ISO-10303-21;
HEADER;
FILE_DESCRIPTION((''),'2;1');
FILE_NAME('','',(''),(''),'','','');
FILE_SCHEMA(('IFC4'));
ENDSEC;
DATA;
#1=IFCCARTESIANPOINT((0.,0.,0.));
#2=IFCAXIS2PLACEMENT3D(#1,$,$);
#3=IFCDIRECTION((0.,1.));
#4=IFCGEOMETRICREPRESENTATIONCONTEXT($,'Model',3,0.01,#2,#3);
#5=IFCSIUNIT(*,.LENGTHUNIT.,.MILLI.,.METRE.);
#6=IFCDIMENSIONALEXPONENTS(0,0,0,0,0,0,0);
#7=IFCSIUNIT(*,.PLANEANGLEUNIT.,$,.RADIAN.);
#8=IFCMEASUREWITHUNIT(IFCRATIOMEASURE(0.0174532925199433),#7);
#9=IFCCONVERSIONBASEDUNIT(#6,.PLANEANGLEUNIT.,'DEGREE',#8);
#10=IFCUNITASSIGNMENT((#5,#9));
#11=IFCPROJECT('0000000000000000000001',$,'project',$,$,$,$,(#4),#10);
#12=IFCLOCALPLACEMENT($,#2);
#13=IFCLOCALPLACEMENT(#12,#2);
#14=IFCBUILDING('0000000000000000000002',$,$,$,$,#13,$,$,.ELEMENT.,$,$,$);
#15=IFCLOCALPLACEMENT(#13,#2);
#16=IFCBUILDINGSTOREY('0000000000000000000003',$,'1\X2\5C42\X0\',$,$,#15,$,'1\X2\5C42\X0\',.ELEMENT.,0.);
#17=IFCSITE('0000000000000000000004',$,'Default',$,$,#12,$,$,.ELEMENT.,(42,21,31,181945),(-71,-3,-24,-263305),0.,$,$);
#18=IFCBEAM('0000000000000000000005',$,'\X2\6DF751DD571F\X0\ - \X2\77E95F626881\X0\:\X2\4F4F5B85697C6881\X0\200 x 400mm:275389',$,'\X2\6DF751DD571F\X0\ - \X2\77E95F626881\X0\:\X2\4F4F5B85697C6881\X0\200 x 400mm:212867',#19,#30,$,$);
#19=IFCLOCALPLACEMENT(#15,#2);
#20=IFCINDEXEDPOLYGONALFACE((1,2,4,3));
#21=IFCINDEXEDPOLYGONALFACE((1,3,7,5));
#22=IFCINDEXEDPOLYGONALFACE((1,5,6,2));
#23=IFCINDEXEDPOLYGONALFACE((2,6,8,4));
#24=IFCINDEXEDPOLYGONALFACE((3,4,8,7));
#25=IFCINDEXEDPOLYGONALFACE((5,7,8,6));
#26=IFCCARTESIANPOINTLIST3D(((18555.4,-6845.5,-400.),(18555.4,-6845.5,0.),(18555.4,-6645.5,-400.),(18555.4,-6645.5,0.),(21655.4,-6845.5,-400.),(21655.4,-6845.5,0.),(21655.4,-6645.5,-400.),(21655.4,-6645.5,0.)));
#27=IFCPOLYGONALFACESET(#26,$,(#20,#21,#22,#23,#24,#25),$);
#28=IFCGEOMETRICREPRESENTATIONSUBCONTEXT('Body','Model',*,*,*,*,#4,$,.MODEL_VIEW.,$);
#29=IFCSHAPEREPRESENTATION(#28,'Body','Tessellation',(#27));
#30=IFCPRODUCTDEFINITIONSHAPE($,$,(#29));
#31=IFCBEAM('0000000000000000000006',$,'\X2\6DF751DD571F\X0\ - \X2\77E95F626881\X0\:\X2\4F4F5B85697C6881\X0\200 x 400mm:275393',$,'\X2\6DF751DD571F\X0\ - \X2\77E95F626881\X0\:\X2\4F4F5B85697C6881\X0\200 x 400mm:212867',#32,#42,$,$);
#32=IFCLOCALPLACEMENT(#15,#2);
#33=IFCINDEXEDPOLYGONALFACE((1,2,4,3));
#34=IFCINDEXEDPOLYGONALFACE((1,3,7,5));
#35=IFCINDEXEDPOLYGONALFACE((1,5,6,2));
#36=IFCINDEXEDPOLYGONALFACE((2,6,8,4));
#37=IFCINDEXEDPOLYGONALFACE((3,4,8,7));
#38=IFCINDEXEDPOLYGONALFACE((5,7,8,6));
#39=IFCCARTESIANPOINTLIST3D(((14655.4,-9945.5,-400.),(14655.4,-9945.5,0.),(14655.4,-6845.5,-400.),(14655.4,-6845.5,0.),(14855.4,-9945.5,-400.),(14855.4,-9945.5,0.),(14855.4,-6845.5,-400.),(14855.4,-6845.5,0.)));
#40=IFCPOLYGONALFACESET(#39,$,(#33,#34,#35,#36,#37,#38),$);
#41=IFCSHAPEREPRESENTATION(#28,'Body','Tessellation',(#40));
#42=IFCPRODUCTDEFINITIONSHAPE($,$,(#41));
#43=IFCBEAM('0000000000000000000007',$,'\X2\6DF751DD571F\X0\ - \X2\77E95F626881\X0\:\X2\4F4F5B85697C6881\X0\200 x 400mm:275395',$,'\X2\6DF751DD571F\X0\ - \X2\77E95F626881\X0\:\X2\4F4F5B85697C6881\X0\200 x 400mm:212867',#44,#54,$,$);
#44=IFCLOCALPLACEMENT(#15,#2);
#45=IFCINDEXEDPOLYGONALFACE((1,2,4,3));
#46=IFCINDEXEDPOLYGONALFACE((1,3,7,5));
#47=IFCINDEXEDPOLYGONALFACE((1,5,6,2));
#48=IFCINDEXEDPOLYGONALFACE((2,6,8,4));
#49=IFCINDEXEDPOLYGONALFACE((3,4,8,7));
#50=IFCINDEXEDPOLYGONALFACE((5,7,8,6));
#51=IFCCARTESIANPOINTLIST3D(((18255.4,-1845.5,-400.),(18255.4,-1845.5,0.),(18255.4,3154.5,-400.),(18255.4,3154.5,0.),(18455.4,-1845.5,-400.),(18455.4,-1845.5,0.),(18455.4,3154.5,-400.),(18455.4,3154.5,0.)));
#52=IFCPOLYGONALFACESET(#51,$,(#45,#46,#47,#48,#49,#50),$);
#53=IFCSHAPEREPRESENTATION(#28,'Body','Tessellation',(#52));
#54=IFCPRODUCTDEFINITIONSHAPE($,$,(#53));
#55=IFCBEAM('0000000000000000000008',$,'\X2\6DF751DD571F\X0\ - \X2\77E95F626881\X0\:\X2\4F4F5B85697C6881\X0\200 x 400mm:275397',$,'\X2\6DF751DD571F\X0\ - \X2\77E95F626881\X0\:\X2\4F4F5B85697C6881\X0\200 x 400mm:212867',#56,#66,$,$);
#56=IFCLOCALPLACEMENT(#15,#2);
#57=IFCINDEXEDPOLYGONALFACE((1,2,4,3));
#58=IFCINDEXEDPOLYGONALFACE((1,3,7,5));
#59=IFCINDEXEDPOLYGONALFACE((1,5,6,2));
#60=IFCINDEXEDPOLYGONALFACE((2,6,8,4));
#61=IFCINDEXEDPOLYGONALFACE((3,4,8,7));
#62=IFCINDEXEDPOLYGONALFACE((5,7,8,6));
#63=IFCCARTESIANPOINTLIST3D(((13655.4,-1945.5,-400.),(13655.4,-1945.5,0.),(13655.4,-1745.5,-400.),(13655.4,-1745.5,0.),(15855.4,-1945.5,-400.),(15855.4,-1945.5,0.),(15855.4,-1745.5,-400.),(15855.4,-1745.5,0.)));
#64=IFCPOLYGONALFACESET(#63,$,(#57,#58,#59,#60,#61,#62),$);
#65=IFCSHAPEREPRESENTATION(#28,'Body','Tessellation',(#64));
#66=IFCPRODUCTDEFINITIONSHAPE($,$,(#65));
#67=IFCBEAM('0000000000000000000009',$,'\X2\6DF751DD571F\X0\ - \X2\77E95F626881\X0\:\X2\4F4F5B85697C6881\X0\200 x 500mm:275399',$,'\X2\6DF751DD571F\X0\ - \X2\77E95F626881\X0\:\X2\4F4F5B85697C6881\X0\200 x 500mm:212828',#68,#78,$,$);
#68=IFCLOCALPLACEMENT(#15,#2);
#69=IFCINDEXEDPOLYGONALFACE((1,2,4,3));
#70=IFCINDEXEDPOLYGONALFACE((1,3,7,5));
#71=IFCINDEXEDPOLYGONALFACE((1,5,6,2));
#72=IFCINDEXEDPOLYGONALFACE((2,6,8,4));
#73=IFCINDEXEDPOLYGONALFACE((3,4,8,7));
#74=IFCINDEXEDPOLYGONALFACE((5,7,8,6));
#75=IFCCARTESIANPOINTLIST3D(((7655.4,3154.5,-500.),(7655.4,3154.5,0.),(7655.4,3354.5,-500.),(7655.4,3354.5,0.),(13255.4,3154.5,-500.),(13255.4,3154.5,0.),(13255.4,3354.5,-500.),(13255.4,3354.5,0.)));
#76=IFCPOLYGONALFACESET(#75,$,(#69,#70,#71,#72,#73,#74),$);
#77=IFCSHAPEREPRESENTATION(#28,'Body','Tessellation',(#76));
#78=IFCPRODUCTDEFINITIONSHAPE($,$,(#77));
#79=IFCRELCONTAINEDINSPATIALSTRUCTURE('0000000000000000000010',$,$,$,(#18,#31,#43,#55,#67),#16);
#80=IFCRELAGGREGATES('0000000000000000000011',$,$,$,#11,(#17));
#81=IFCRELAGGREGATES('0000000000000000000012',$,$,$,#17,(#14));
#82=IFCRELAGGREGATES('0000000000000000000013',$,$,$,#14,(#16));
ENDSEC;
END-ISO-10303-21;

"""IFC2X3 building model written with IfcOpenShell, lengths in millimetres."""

from ifc_helpers import new_model, entity, si_unit, converted_unit, direction, frame, frame_2d, origin, place, context, subcontext, project, spatial, rectangle, extrude, element, save


model = new_model("IFC2X3")

# Units and contexts
model_context = context("Model", 3, precision=0.01, world=origin(), true_north=direction((0.0, 1.0)))
body_context = subcontext(model_context, "Body", "Model", "MODEL_VIEW")
ifc_project = project(units=[si_unit("LENGTHUNIT", "METRE", prefix="MILLI"), converted_unit("PLANEANGLEUNIT", "DEGREE", entity("IfcRatioMeasure", 0.0174532925199433), si_unit("PLANEANGLEUNIT", "RADIAN"), dimensions=[0, 0, 0, 0, 0, 0, 0])], contexts=[model_context])

# Site, building, storey
site_placement = place(None, origin())
site = spatial("IfcSite", under=ifc_project, at=site_placement, Name="Default", CompositionType="ELEMENT", RefLatitude=(42, 21, 31, 181945), RefLongitude=(-71, -3, -24, -263305), RefElevation=0.0)
building_placement = place(site_placement, origin())
building = spatial("IfcBuilding", under=site, at=building_placement, CompositionType="ELEMENT")
storey_placement = place(building_placement, origin())
storey = spatial("IfcBuildingStorey", under=building, at=storey_placement, Name="1层", LongName="1层", CompositionType="ELEMENT", Elevation=0.0)

# Beams
beam_1_placement = place(storey_placement, frame((18355.4, -6745.5, 0.0)))
element("IfcBeam", 1, at=beam_1_placement, inside=storey, Name="混凝土 - 矩形梁:住宅楼梁200 x 400mm:275389", ObjectType="混凝土 - 矩形梁:住宅楼梁200 x 400mm:212867", context=body_context, shape_type="SweptSolid", body=[
    extrude(rectangle(XDim=400.0, YDim=200.0, at=frame_2d((0.0, 0.0), x_axis=(1.0, 0.0))), frame((200.0, 0.0, -200.0), z_axis=(1.0, 0.0, 0.0), x_axis=(0.0, 0.0, -1.0)), (0.0, 0.0, 1.0), 3100.0),
])
beam_2_placement = place(storey_placement, frame((14755.4, -10145.5, 0.0), z_axis=(0.0, 0.0, 1.0), x_axis=(0.0, 1.0, 0.0)))
element("IfcBeam", 2, at=beam_2_placement, inside=storey, Name="混凝土 - 矩形梁:住宅楼梁200 x 400mm:275393", ObjectType="混凝土 - 矩形梁:住宅楼梁200 x 400mm:212867", context=body_context, shape_type="SweptSolid", body=[
    extrude(rectangle(XDim=400.0, YDim=200.0, at=frame_2d((0.0, 0.0), x_axis=(1.0, 0.0))), frame((200.0, 0.0, -200.0), z_axis=(1.0, 0.0, 0.0), x_axis=(0.0, 0.0, -1.0)), (0.0, 0.0, 1.0), 3100.0),
])
beam_3_placement = place(storey_placement, frame((18355.4, 3254.5, 0.0), z_axis=(0.0, 0.0, 1.0), x_axis=(0.0, -1.0, 0.0)))
element("IfcBeam", 3, at=beam_3_placement, inside=storey, Name="混凝土 - 矩形梁:住宅楼梁200 x 400mm:275395", ObjectType="混凝土 - 矩形梁:住宅楼梁200 x 400mm:212867", context=body_context, shape_type="SweptSolid", body=[
    extrude(rectangle(XDim=400.0, YDim=200.0, at=frame_2d((0.0, 0.0), x_axis=(1.0, 0.0))), frame((100.0, 0.0, -200.0), z_axis=(1.0, 0.0, 0.0), x_axis=(0.0, 0.0, -1.0)), (0.0, 0.0, 1.0), 5000.0),
])
beam_4_placement = place(storey_placement, frame((16055.4, -1845.5, 0.0), z_axis=(0.0, 0.0, 1.0), x_axis=(-1.0, 0.0, 0.0)))
element("IfcBeam", 4, at=beam_4_placement, inside=storey, Name="混凝土 - 矩形梁:住宅楼梁200 x 400mm:275397", ObjectType="混凝土 - 矩形梁:住宅楼梁200 x 400mm:212867", context=body_context, shape_type="SweptSolid", body=[
    extrude(rectangle(XDim=400.0, YDim=200.0, at=frame_2d((0.0, 0.0), x_axis=(1.0, 0.0))), frame((200.0, 0.0, -200.0), z_axis=(1.0, 0.0, 0.0), x_axis=(0.0, 0.0, -1.0)), (0.0, 0.0, 1.0), 2200.0),
])
beam_5_placement = place(storey_placement, frame((7555.4, 3254.5, 0.0)))
element("IfcBeam", 5, at=beam_5_placement, inside=storey, Name="混凝土 - 矩形梁:住宅楼梁200 x 500mm:275399", ObjectType="混凝土 - 矩形梁:住宅楼梁200 x 500mm:212828", context=body_context, shape_type="SweptSolid", body=[
    extrude(rectangle(XDim=500.0, YDim=200.0, at=frame_2d((0.0, 0.0), x_axis=(1.0, 0.0))), frame((100.0, 0.0, -250.0), z_axis=(1.0, 0.0, 0.0), x_axis=(0.0, 0.0, -1.0)), (0.0, 0.0, 1.0), 5600.0),
])

save(model, "model.ifc")
